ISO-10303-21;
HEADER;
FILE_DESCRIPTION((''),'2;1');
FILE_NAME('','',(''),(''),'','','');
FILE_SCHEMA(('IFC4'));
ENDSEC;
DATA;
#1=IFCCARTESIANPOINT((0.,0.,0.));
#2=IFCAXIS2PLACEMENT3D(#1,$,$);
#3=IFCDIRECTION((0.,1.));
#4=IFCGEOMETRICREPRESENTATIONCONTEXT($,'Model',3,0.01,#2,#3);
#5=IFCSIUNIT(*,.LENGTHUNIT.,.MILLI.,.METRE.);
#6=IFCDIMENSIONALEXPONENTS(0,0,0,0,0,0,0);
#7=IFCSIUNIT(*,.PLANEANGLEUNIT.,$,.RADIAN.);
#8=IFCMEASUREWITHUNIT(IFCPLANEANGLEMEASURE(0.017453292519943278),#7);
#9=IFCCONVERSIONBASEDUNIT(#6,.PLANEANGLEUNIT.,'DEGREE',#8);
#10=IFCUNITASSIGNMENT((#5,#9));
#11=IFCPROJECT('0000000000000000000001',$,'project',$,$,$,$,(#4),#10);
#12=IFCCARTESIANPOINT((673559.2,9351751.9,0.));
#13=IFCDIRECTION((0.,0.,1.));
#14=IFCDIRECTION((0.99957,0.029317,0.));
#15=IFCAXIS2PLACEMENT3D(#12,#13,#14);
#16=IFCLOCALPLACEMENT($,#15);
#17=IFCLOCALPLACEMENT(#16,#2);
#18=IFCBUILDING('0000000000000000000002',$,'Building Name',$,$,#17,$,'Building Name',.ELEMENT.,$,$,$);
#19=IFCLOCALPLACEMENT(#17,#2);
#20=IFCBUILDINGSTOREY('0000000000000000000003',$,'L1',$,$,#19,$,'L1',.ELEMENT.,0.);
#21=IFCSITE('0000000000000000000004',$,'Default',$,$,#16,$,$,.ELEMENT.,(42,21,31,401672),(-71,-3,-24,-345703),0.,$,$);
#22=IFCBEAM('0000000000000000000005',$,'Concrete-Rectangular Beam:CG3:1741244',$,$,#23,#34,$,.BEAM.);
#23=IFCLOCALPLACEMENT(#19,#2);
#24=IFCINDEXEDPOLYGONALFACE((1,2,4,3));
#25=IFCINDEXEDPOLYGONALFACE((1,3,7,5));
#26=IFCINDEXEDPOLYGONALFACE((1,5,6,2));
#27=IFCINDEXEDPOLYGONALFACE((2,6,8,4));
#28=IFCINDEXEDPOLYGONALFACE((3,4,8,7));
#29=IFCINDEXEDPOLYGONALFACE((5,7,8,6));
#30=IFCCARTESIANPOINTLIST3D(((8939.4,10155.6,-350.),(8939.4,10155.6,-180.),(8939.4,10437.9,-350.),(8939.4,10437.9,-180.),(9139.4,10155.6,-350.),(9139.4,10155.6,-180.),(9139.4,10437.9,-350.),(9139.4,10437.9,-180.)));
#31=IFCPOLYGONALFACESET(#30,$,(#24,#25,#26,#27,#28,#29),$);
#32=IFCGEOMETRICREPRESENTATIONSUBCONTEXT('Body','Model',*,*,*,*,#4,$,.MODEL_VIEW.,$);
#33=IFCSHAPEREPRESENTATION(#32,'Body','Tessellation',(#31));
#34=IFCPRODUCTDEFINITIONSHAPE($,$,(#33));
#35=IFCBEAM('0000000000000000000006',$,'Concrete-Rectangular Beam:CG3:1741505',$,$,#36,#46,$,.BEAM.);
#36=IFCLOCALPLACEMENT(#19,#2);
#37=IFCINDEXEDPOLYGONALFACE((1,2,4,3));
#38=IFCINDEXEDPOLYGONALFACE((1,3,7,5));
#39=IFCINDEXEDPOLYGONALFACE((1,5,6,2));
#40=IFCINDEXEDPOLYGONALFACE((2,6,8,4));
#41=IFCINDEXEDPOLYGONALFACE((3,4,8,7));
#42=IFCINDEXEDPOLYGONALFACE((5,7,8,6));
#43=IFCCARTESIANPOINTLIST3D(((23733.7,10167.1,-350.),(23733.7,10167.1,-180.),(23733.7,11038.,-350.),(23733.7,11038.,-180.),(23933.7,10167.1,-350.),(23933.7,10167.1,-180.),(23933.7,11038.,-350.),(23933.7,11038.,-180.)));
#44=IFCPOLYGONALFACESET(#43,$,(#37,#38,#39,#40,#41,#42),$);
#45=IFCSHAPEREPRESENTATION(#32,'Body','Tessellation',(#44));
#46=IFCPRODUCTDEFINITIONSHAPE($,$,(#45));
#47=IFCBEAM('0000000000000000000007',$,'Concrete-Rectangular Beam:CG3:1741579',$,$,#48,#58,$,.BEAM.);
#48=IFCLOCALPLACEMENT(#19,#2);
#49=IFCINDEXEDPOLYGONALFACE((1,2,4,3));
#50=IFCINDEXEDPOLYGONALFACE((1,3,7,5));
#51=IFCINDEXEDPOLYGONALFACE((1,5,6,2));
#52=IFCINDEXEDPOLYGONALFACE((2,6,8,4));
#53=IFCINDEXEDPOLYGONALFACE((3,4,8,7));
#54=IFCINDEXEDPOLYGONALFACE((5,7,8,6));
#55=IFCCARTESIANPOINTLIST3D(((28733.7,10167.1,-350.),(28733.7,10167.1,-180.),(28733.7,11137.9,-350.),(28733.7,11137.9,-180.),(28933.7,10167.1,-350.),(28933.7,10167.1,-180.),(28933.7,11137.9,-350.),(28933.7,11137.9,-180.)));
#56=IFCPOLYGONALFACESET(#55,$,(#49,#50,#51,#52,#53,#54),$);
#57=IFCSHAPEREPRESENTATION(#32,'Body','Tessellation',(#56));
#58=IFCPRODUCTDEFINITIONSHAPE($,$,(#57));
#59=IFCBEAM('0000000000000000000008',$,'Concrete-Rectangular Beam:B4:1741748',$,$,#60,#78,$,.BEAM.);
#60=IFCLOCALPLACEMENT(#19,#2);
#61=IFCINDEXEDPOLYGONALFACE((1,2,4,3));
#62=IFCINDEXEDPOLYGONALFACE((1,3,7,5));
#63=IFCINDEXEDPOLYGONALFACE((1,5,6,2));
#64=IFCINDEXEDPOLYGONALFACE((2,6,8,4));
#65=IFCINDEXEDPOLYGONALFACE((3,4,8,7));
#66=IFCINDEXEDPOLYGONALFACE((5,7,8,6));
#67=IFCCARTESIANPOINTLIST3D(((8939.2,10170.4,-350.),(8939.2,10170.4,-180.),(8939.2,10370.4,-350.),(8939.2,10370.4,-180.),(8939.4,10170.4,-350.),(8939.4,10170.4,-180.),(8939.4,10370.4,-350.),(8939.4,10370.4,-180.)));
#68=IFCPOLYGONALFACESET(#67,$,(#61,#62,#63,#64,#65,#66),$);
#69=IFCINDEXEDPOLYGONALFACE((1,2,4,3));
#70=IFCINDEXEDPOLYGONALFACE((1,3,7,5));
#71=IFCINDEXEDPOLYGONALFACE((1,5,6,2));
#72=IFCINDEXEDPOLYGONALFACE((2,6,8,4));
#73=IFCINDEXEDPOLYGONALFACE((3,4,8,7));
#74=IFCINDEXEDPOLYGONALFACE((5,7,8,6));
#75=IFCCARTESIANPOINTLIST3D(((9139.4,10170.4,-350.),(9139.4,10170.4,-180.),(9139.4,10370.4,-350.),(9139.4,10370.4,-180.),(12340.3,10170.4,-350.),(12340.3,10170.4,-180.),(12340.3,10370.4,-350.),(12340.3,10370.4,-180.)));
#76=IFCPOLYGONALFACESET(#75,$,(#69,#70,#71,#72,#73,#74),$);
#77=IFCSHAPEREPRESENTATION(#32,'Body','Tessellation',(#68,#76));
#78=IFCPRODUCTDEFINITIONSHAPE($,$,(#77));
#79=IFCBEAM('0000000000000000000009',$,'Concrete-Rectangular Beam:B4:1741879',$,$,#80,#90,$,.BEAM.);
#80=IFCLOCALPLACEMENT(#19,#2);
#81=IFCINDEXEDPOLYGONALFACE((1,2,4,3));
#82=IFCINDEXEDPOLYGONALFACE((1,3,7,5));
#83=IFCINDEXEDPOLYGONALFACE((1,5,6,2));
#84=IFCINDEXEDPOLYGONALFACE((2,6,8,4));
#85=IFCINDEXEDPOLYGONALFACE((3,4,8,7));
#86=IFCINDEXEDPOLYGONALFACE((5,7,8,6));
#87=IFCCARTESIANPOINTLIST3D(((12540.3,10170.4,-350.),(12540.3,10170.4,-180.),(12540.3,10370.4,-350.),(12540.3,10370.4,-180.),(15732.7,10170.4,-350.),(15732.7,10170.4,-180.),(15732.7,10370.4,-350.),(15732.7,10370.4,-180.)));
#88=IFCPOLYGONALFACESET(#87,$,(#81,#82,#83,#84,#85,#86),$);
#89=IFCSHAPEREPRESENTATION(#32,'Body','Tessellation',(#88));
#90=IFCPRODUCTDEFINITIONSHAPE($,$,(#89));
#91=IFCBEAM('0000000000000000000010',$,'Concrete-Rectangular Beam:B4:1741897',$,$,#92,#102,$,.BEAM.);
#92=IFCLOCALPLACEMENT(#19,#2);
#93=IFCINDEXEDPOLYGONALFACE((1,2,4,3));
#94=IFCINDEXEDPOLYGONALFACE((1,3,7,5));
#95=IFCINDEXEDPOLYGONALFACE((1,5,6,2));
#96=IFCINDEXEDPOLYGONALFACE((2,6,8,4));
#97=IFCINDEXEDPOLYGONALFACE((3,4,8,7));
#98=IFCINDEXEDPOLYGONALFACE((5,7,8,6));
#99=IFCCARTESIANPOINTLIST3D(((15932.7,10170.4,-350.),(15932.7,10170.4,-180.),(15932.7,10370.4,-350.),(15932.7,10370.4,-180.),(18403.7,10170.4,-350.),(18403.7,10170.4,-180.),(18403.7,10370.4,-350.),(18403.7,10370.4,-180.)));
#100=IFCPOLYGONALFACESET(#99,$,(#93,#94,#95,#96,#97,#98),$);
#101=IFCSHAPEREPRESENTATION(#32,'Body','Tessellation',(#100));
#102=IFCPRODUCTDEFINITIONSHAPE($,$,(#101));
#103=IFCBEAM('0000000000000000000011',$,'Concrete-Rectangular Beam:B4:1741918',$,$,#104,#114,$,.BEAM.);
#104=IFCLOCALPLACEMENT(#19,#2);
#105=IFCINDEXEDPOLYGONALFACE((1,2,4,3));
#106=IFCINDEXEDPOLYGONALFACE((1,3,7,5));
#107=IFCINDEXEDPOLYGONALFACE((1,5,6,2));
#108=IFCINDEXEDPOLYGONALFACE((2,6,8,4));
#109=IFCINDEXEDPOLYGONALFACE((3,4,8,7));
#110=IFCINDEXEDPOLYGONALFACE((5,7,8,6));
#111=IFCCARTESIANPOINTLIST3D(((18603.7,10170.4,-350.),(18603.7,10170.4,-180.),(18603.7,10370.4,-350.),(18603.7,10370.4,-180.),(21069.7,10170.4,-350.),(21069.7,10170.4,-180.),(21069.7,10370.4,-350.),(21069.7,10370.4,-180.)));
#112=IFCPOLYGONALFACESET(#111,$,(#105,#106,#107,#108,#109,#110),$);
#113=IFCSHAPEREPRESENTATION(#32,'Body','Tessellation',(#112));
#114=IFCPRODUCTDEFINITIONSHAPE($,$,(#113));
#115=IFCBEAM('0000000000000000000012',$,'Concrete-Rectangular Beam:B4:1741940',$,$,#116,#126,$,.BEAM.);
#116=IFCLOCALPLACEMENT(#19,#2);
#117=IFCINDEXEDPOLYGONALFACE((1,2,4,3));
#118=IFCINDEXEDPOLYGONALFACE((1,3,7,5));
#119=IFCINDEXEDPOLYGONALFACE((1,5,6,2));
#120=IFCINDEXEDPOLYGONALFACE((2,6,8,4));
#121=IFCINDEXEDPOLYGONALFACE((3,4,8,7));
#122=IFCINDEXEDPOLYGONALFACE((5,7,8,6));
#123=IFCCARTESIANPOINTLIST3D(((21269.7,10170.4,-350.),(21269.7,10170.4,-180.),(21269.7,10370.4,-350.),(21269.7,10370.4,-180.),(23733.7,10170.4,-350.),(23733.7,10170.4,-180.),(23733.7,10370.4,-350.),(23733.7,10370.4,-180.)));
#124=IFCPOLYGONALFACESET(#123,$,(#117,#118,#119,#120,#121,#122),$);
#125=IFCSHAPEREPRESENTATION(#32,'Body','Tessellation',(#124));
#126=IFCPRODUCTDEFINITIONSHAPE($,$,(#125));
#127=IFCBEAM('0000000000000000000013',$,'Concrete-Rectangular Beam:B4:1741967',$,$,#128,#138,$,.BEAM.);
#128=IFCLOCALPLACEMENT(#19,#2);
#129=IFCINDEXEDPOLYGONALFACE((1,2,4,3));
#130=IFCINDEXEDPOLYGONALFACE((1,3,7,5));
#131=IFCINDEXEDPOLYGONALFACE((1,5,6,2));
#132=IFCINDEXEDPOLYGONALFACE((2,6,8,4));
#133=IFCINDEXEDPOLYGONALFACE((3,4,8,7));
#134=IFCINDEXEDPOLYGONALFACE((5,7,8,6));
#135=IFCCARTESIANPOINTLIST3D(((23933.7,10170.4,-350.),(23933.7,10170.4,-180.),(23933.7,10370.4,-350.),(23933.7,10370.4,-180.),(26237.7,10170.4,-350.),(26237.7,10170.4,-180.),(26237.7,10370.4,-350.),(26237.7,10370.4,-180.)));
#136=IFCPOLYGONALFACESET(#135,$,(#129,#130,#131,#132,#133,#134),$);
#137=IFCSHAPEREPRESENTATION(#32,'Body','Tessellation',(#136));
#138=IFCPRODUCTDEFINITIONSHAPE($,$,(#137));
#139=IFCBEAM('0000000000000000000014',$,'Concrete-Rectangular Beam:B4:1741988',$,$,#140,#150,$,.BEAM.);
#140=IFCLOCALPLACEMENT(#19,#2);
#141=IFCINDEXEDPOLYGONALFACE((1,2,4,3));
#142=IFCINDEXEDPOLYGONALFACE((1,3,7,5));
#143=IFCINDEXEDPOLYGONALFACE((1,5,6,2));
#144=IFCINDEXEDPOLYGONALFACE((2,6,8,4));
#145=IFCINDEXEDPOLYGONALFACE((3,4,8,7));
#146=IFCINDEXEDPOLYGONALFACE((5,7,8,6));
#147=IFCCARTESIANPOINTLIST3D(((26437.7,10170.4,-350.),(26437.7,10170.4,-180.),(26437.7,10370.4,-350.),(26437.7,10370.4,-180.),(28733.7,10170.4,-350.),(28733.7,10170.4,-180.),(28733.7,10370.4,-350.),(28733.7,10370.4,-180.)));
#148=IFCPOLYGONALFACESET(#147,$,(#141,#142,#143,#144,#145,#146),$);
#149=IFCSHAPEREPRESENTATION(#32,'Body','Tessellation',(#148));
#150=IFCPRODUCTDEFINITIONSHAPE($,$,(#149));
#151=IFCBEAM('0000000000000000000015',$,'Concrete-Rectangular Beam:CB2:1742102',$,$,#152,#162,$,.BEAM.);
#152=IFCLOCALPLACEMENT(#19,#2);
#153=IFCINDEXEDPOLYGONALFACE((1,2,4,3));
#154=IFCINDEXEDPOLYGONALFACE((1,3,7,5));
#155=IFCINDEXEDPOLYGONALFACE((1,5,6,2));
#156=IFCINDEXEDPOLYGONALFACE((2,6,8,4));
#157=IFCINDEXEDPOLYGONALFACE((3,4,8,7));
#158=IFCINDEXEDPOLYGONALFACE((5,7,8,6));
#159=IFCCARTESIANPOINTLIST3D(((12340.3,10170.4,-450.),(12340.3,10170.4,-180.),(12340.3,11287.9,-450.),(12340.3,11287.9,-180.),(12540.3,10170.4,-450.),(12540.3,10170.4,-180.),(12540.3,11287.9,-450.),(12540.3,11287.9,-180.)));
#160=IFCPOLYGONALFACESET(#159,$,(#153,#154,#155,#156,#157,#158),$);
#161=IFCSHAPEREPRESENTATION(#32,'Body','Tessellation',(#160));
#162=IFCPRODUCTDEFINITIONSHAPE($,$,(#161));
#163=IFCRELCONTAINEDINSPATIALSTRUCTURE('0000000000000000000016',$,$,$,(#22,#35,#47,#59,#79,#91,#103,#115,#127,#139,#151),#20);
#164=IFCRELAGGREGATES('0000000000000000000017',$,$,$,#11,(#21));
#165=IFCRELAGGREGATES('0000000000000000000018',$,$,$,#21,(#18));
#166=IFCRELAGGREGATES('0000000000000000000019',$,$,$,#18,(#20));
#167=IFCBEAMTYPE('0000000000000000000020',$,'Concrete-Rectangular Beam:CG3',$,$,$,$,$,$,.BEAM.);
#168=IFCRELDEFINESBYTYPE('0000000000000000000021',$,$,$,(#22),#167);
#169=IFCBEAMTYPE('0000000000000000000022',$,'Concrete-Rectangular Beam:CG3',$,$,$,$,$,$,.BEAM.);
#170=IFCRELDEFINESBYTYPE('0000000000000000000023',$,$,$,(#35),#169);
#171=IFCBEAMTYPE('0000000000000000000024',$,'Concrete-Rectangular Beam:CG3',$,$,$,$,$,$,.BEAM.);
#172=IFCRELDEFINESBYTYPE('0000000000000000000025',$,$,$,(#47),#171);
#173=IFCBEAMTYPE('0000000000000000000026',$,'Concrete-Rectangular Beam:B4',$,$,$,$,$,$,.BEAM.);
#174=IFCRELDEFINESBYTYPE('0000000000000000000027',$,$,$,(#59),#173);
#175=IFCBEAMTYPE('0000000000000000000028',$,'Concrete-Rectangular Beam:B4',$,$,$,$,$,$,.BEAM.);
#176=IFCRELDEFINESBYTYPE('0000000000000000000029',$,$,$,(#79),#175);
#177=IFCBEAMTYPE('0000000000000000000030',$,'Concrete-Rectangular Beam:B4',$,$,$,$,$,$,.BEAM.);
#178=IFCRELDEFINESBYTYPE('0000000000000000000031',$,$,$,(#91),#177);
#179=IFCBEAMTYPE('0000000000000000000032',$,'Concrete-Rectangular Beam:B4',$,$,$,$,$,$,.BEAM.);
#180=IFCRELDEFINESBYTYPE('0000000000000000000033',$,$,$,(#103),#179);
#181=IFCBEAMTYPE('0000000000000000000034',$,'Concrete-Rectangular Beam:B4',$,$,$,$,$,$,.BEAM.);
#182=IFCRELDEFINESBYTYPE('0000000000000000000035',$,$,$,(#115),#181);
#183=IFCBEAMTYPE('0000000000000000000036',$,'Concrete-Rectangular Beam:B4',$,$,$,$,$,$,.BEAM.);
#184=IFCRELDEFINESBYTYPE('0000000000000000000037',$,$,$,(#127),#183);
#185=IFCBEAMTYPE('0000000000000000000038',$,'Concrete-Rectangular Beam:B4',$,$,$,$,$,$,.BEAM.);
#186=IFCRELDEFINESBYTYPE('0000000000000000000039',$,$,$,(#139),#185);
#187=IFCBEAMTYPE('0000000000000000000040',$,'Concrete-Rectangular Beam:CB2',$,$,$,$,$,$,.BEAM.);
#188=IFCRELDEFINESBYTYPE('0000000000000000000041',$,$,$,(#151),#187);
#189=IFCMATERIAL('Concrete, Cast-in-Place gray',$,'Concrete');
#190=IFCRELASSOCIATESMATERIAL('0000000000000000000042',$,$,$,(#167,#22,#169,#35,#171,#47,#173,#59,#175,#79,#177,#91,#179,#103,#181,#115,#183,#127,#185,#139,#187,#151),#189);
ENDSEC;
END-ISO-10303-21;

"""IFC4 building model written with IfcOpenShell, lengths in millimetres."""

from ifc_helpers import new_model, entity, si_unit, converted_unit, direction, frame, origin, place, context, subcontext, project, spatial, indexed_curve, outline, extrude, source, transform, mapped, material, type_object, type_shapes, element, save


model = new_model("IFC4")

# Units and contexts
model_context = context("Model", 3, precision=0.01, world=origin(), true_north=direction((0.0, 1.0)))
body_context = subcontext(model_context, "Body", "Model", "MODEL_VIEW")
ifc_project = project(units=[si_unit("LENGTHUNIT", "METRE", prefix="MILLI"), converted_unit("PLANEANGLEUNIT", "DEGREE", entity("IfcPlaneAngleMeasure", 0.017453292519943278), si_unit("PLANEANGLEUNIT", "RADIAN"), dimensions=[0, 0, 0, 0, 0, 0, 0])], contexts=[model_context])

# Site, building, storey
site_placement = place(None, frame((673559.2, 9351751.9, 0.0), z_axis=(0.0, 0.0, 1.0), x_axis=(0.99957, 0.029317, 0.0)))
site = spatial("IfcSite", under=ifc_project, at=site_placement, Name="Default", CompositionType="ELEMENT", RefLatitude=(42, 21, 31, 401672), RefLongitude=(-71, -3, -24, -345703), RefElevation=0.0)
building_placement = place(site_placement, origin())
building = spatial("IfcBuilding", under=site, at=building_placement, Name="Building Name", LongName="Building Name", CompositionType="ELEMENT")
storey_placement = place(building_placement, origin())
storey = spatial("IfcBuildingStorey", under=building, at=storey_placement, Name="L1", LongName="L1", CompositionType="ELEMENT", Elevation=0.0)

# Beams
ifc_material = material(Name="Concrete, Cast-in-Place gray", Category="Concrete")
beam_type_1 = type_object("IfcBeamType", Name="Concrete-Rectangular Beam:CG3", PredefinedType="BEAM", material=ifc_material)
shared_shape_1 = source(origin(), body_context, "Body", "SweptSolid", [
    extrude(outline(indexed_curve([(-100.0, -85.0), (100.0, -85.0), (100.0, 85.0), (-100.0, 85.0), (-100.0, -85.0)], self_intersect=False)), frame((9039.4, 10437.9, -265.0), z_axis=(0.0, -1.0, 0.0), x_axis=(-1.0, 0.0, 0.0)), (0.0, 0.0, 1.0), 282.3),
])
type_shapes(beam_type_1, [shared_shape_1])
beam_1_placement = place(storey_placement, origin())
element("IfcBeam", 1, at=beam_1_placement, inside=storey, type_object=beam_type_1, material=ifc_material, Name="Concrete-Rectangular Beam:CG3:1741244", PredefinedType="BEAM", context=body_context, shape_type="MappedRepresentation", body=[
    mapped(shared_shape_1, transform((0.0, 0.0, 0.0), scale=1.0)),
])
beam_type_2 = type_object("IfcBeamType", Name="Concrete-Rectangular Beam:CG3", PredefinedType="BEAM", material=ifc_material)
shared_shape_2 = source(origin(), body_context, "Body", "SweptSolid", [
    extrude(outline(indexed_curve([(-100.0, -85.0), (100.0, -85.0), (100.0, 85.0), (-100.0, 85.0), (-100.0, -85.0)], self_intersect=False)), frame((23833.7, 11038.0, -265.0), z_axis=(0.0, -1.0, 0.0), x_axis=(-1.0, 0.0, 0.0)), (0.0, 0.0, 1.0), 870.9),
])
type_shapes(beam_type_2, [shared_shape_2])
beam_2_placement = place(storey_placement, origin())
element("IfcBeam", 2, at=beam_2_placement, inside=storey, type_object=beam_type_2, material=ifc_material, Name="Concrete-Rectangular Beam:CG3:1741505", PredefinedType="BEAM", context=body_context, shape_type="MappedRepresentation", body=[
    mapped(shared_shape_2, transform((0.0, 0.0, 0.0), scale=1.0)),
])
beam_type_3 = type_object("IfcBeamType", Name="Concrete-Rectangular Beam:CG3", PredefinedType="BEAM", material=ifc_material)
shared_shape_3 = source(origin(), body_context, "Body", "SweptSolid", [
    extrude(outline(indexed_curve([(-100.0, -85.0), (100.0, -85.0), (100.0, 85.0), (-100.0, 85.0), (-100.0, -85.0)], self_intersect=False)), frame((28833.7, 11137.9, -265.0), z_axis=(0.0, -1.0, 0.0), x_axis=(-1.0, 0.0, 0.0)), (0.0, 0.0, 1.0), 970.8),
])
type_shapes(beam_type_3, [shared_shape_3])
beam_3_placement = place(storey_placement, origin())
element("IfcBeam", 3, at=beam_3_placement, inside=storey, type_object=beam_type_3, material=ifc_material, Name="Concrete-Rectangular Beam:CG3:1741579", PredefinedType="BEAM", context=body_context, shape_type="MappedRepresentation", body=[
    mapped(shared_shape_3, transform((0.0, 0.0, 0.0), scale=1.0)),
])
beam_type_4 = type_object("IfcBeamType", Name="Concrete-Rectangular Beam:B4", PredefinedType="BEAM", material=ifc_material)
shared_shape_4 = source(origin(), body_context, "Body", "SweptSolid", [
    extrude(outline(indexed_curve([(-85.0, -100.0), (85.0, -100.0), (85.0, 100.0), (-85.0, 100.0), (-85.0, -100.0)], self_intersect=False)), frame((8939.2, 10270.4, -265.0), z_axis=(1.0, 0.0, 0.0), x_axis=(0.0, 0.0, -1.0)), (0.0, 0.0, 1.0), 0.2),
    extrude(outline(indexed_curve([(-85.0, -100.0), (85.0, -100.0), (85.0, 100.0), (-85.0, 100.0), (-85.0, -100.0)], self_intersect=False)), frame((9139.4, 10270.4, -265.0), z_axis=(1.0, 0.0, 0.0), x_axis=(0.0, 0.0, -1.0)), (0.0, 0.0, 1.0), 3200.9),
])
type_shapes(beam_type_4, [shared_shape_4])
beam_4_placement = place(storey_placement, origin())
element("IfcBeam", 4, at=beam_4_placement, inside=storey, type_object=beam_type_4, material=ifc_material, Name="Concrete-Rectangular Beam:B4:1741748", PredefinedType="BEAM", context=body_context, shape_type="MappedRepresentation", body=[
    mapped(shared_shape_4, transform((0.0, 0.0, 0.0), scale=1.0)),
])
beam_type_5 = type_object("IfcBeamType", Name="Concrete-Rectangular Beam:B4", PredefinedType="BEAM", material=ifc_material)
shared_shape_5 = source(origin(), body_context, "Body", "SweptSolid", [
    extrude(outline(indexed_curve([(-85.0, -100.0), (85.0, -100.0), (85.0, 100.0), (-85.0, 100.0), (-85.0, -100.0)], self_intersect=False)), frame((12540.3, 10270.4, -265.0), z_axis=(1.0, 0.0, 0.0), x_axis=(0.0, 0.0, -1.0)), (0.0, 0.0, 1.0), 3192.4),
])
type_shapes(beam_type_5, [shared_shape_5])
beam_5_placement = place(storey_placement, origin())
element("IfcBeam", 5, at=beam_5_placement, inside=storey, type_object=beam_type_5, material=ifc_material, Name="Concrete-Rectangular Beam:B4:1741879", PredefinedType="BEAM", context=body_context, shape_type="MappedRepresentation", body=[
    mapped(shared_shape_5, transform((0.0, 0.0, 0.0), scale=1.0)),
])
beam_type_6 = type_object("IfcBeamType", Name="Concrete-Rectangular Beam:B4", PredefinedType="BEAM", material=ifc_material)
shared_shape_6 = source(origin(), body_context, "Body", "SweptSolid", [
    extrude(outline(indexed_curve([(-85.0, -100.0), (85.0, -100.0), (85.0, 100.0), (-85.0, 100.0), (-85.0, -100.0)], self_intersect=False)), frame((15932.7, 10270.4, -265.0), z_axis=(1.0, 0.0, 0.0), x_axis=(0.0, 0.0, -1.0)), (0.0, 0.0, 1.0), 2471.0),
])
type_shapes(beam_type_6, [shared_shape_6])
beam_6_placement = place(storey_placement, origin())
element("IfcBeam", 6, at=beam_6_placement, inside=storey, type_object=beam_type_6, material=ifc_material, Name="Concrete-Rectangular Beam:B4:1741897", PredefinedType="BEAM", context=body_context, shape_type="MappedRepresentation", body=[
    mapped(shared_shape_6, transform((0.0, 0.0, 0.0), scale=1.0)),
])
beam_type_7 = type_object("IfcBeamType", Name="Concrete-Rectangular Beam:B4", PredefinedType="BEAM", material=ifc_material)
shared_shape_7 = source(origin(), body_context, "Body", "SweptSolid", [
    extrude(outline(indexed_curve([(-85.0, -100.0), (85.0, -100.0), (85.0, 100.0), (-85.0, 100.0), (-85.0, -100.0)], self_intersect=False)), frame((18603.7, 10270.4, -265.0), z_axis=(1.0, 0.0, 0.0), x_axis=(0.0, 0.0, -1.0)), (0.0, 0.0, 1.0), 2466.0),
])
type_shapes(beam_type_7, [shared_shape_7])
beam_7_placement = place(storey_placement, origin())
element("IfcBeam", 7, at=beam_7_placement, inside=storey, type_object=beam_type_7, material=ifc_material, Name="Concrete-Rectangular Beam:B4:1741918", PredefinedType="BEAM", context=body_context, shape_type="MappedRepresentation", body=[
    mapped(shared_shape_7, transform((0.0, 0.0, 0.0), scale=1.0)),
])
beam_type_8 = type_object("IfcBeamType", Name="Concrete-Rectangular Beam:B4", PredefinedType="BEAM", material=ifc_material)
shared_shape_8 = source(origin(), body_context, "Body", "SweptSolid", [
    extrude(outline(indexed_curve([(-85.0, -100.0), (85.0, -100.0), (85.0, 100.0), (-85.0, 100.0), (-85.0, -100.0)], self_intersect=False)), frame((21269.7, 10270.4, -265.0), z_axis=(1.0, 0.0, 0.0), x_axis=(0.0, 0.0, -1.0)), (0.0, 0.0, 1.0), 2464.0),
])
type_shapes(beam_type_8, [shared_shape_8])
beam_8_placement = place(storey_placement, origin())
element("IfcBeam", 8, at=beam_8_placement, inside=storey, type_object=beam_type_8, material=ifc_material, Name="Concrete-Rectangular Beam:B4:1741940", PredefinedType="BEAM", context=body_context, shape_type="MappedRepresentation", body=[
    mapped(shared_shape_8, transform((0.0, 0.0, 0.0), scale=1.0)),
])
beam_type_9 = type_object("IfcBeamType", Name="Concrete-Rectangular Beam:B4", PredefinedType="BEAM", material=ifc_material)
shared_shape_9 = source(origin(), body_context, "Body", "SweptSolid", [
    extrude(outline(indexed_curve([(-85.0, -100.0), (85.0, -100.0), (85.0, 100.0), (-85.0, 100.0), (-85.0, -100.0)], self_intersect=False)), frame((23933.7, 10270.4, -265.0), z_axis=(1.0, 0.0, 0.0), x_axis=(0.0, 0.0, -1.0)), (0.0, 0.0, 1.0), 2304.0),
])
type_shapes(beam_type_9, [shared_shape_9])
beam_9_placement = place(storey_placement, origin())
element("IfcBeam", 9, at=beam_9_placement, inside=storey, type_object=beam_type_9, material=ifc_material, Name="Concrete-Rectangular Beam:B4:1741967", PredefinedType="BEAM", context=body_context, shape_type="MappedRepresentation", body=[
    mapped(shared_shape_9, transform((0.0, 0.0, 0.0), scale=1.0)),
])
beam_type_10 = type_object("IfcBeamType", Name="Concrete-Rectangular Beam:B4", PredefinedType="BEAM", material=ifc_material)
shared_shape_10 = source(origin(), body_context, "Body", "SweptSolid", [
    extrude(outline(indexed_curve([(-85.0, -100.0), (85.0, -100.0), (85.0, 100.0), (-85.0, 100.0), (-85.0, -100.0)], self_intersect=False)), frame((26437.7, 10270.4, -265.0), z_axis=(1.0, 0.0, 0.0), x_axis=(0.0, 0.0, -1.0)), (0.0, 0.0, 1.0), 2296.0),
])
type_shapes(beam_type_10, [shared_shape_10])
beam_10_placement = place(storey_placement, origin())
element("IfcBeam", 10, at=beam_10_placement, inside=storey, type_object=beam_type_10, material=ifc_material, Name="Concrete-Rectangular Beam:B4:1741988", PredefinedType="BEAM", context=body_context, shape_type="MappedRepresentation", body=[
    mapped(shared_shape_10, transform((0.0, 0.0, 0.0), scale=1.0)),
])
beam_type_11 = type_object("IfcBeamType", Name="Concrete-Rectangular Beam:CB2", PredefinedType="BEAM", material=ifc_material)
shared_shape_11 = source(origin(), body_context, "Body", "SweptSolid", [
    extrude(outline(indexed_curve([(-100.0, -135.0), (100.0, -135.0), (100.0, 135.0), (-100.0, 135.0), (-100.0, -135.0)], self_intersect=False)), frame((12440.3, 11287.9, -315.0), z_axis=(0.0, -1.0, 0.0), x_axis=(-1.0, 0.0, 0.0)), (0.0, 0.0, 1.0), 1117.5),
])
type_shapes(beam_type_11, [shared_shape_11])
beam_11_placement = place(storey_placement, origin())
element("IfcBeam", 11, at=beam_11_placement, inside=storey, type_object=beam_type_11, material=ifc_material, Name="Concrete-Rectangular Beam:CB2:1742102", PredefinedType="BEAM", context=body_context, shape_type="MappedRepresentation", body=[
    mapped(shared_shape_11, transform((0.0, 0.0, 0.0), scale=1.0)),
])

save(model, "model.ifc")
